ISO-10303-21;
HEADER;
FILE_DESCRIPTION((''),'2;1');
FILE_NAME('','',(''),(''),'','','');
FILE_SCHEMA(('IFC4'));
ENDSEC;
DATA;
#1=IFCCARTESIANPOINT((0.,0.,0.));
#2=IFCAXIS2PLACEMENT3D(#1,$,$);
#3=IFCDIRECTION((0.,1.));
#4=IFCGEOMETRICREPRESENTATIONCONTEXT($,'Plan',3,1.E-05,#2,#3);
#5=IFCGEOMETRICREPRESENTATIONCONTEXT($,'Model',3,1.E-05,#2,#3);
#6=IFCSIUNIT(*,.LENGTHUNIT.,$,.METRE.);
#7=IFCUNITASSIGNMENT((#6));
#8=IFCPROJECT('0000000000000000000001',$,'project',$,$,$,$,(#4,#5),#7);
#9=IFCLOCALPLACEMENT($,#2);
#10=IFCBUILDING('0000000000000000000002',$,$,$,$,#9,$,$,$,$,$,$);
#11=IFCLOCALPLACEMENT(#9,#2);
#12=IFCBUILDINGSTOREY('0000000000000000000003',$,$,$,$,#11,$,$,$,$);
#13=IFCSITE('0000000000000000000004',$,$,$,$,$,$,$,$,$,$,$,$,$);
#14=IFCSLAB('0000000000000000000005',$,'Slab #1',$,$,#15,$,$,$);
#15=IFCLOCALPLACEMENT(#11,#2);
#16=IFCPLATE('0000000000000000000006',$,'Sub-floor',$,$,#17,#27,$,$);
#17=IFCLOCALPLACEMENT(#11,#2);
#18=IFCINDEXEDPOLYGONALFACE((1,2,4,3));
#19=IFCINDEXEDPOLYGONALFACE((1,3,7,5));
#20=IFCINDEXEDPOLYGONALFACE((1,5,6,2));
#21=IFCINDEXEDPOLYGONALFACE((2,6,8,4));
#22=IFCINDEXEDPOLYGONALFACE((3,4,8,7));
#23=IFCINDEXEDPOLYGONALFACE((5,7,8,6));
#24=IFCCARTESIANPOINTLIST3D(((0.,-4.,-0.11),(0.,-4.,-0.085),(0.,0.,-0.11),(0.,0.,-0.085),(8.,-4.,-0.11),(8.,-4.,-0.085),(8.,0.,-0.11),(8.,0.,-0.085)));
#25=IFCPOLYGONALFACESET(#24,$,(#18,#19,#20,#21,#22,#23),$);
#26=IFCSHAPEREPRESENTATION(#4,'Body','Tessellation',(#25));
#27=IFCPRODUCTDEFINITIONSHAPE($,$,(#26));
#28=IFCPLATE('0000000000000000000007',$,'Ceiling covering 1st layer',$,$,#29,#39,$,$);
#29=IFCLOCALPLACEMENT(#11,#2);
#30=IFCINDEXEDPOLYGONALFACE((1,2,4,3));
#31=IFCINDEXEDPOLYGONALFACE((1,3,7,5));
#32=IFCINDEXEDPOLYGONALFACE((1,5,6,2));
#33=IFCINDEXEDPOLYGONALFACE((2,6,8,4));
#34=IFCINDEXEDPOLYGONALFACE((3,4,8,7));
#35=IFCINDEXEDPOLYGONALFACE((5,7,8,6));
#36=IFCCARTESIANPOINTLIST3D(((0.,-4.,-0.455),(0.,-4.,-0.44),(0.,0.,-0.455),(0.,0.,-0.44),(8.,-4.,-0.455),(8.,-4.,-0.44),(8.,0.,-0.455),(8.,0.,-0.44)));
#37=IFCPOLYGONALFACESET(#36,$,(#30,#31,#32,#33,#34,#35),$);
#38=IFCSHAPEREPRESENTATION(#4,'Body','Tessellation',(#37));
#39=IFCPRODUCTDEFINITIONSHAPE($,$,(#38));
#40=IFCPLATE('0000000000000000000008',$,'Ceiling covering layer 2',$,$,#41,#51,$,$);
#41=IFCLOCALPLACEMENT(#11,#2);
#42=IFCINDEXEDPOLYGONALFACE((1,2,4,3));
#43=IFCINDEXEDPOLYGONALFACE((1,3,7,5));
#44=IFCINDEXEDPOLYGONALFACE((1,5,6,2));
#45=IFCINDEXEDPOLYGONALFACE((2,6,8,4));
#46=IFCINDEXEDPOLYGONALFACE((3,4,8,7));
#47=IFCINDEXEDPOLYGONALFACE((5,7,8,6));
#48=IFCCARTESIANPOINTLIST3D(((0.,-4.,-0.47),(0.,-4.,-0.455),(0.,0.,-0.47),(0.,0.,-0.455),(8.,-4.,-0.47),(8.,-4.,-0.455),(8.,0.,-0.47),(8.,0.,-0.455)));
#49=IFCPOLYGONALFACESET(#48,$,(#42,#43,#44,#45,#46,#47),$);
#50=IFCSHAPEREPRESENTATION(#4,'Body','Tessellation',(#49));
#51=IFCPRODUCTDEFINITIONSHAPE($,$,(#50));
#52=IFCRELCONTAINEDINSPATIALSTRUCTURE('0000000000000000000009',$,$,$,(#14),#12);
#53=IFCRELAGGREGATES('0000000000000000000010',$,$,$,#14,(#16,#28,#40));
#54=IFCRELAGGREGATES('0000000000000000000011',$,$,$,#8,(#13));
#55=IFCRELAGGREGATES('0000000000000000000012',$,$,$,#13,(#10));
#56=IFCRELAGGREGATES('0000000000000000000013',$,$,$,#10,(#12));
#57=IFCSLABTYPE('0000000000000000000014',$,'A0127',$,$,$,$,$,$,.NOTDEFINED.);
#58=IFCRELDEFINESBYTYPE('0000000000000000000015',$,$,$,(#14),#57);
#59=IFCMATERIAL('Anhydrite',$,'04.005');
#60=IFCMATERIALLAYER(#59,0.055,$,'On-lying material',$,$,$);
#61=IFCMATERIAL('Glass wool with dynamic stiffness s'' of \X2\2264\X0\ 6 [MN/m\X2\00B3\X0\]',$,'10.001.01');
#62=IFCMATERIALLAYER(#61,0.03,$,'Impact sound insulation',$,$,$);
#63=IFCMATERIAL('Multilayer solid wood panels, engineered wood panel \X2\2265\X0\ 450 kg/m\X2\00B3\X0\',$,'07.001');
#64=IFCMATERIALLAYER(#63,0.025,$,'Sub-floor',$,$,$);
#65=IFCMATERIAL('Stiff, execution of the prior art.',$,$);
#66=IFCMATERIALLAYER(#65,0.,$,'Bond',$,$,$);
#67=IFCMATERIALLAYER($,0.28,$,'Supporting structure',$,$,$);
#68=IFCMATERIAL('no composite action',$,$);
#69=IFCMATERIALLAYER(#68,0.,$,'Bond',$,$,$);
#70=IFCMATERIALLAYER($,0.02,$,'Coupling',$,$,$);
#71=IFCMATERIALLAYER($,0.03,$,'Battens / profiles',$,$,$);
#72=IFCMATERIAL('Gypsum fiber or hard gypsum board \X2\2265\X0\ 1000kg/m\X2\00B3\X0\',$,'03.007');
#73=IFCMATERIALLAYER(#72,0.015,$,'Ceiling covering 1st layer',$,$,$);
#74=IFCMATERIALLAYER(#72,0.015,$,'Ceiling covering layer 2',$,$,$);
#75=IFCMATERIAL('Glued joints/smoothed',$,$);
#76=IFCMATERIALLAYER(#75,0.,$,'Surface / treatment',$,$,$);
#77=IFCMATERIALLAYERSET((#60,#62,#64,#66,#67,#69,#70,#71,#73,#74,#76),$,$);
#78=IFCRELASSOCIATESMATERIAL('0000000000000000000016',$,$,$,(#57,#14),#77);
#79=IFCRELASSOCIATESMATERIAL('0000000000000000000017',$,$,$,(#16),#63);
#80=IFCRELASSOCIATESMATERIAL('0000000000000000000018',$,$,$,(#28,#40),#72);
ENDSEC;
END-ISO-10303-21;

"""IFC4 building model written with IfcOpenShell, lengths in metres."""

from ifc_helpers import new_model, si_unit, direction, frame, frame_2d, origin, place, context, project, spatial, rectangle, extrude, material, layer, layer_set, type_object, element, aggregate, save


model = new_model("IFC4")

# Units and contexts
plan_context = context("Plan", 3, precision=1e-05, world=origin(), true_north=direction((0.0, 1.0)))
model_context = context("Model", 3, precision=1e-05, world=origin(), true_north=direction((0.0, 1.0)))
ifc_project = project(units=[si_unit("LENGTHUNIT", "METRE")], contexts=[plan_context, model_context])

# Site, building, storey
site = spatial("IfcSite", under=ifc_project)
building_placement = place(None, origin())
building = spatial("IfcBuilding", under=site, at=building_placement)
storey_placement = place(building_placement, origin())
storey = spatial("IfcBuildingStorey", under=building, at=storey_placement)

# Slab, plates
ifc_material_1 = material(Name="Anhydrite", Category="04.005")
ifc_layer_1 = layer(ifc_material_1, 0.055, Name="On-lying material")
ifc_material_2 = material(Name="Glass wool with dynamic stiffness s' of ≤ 6 [MN/m³]", Category="10.001.01")
ifc_layer_2 = layer(ifc_material_2, 0.03, Name="Impact sound insulation")
ifc_material_3 = material(Name="Multilayer solid wood panels, engineered wood panel ≥ 450 kg/m³", Category="07.001")
ifc_layer_3 = layer(ifc_material_3, 0.025, Name="Sub-floor")
ifc_material_4 = material(Name="Stiff, execution of the prior art.")
ifc_layer_4 = layer(ifc_material_4, 0.0, Name="Bond")
ifc_layer_5 = layer(None, 0.28, Name="Supporting structure")
ifc_material_5 = material(Name="no composite action")
ifc_layer_6 = layer(ifc_material_5, 0.0, Name="Bond")
ifc_layer_7 = layer(None, 0.02, Name="Coupling")
ifc_layer_8 = layer(None, 0.03, Name="Battens / profiles")
ifc_material_6 = material(Name="Gypsum fiber or hard gypsum board ≥ 1000kg/m³", Category="03.007")
ifc_layer_9 = layer(ifc_material_6, 0.015, Name="Ceiling covering 1st layer")
ifc_layer_10 = layer(ifc_material_6, 0.015, Name="Ceiling covering layer 2")
ifc_material_7 = material(Name="Glued joints/smoothed")
ifc_layer_11 = layer(ifc_material_7, 0.0, Name="Surface / treatment")
ifc_layer_set = layer_set([ifc_layer_1, ifc_layer_2, ifc_layer_3, ifc_layer_4, ifc_layer_5, ifc_layer_6, ifc_layer_7, ifc_layer_8, ifc_layer_9, ifc_layer_10, ifc_layer_11])
slab_type = type_object("IfcSlabType", Name="A0127", PredefinedType="NOTDEFINED", material=ifc_layer_set)
slab_placement = place(None, frame((0.0, 0.0, 0.0), z_axis=(0.0, 0.0, -1.0), x_axis=(1.0, 0.0, 0.0)))
slab = element("IfcSlab", 1, at=slab_placement, inside=storey, type_object=slab_type, material=ifc_layer_set, Name="Slab #1")
plate_1_placement = place(slab_placement, origin())
plate_1 = element("IfcPlate", 2, at=plate_1_placement, material=ifc_material_3, Name="Sub-floor", context=plan_context, shape_type="SweptSolid", body=[
    extrude(rectangle(XDim=8.0, YDim=4.0, at=frame_2d((4.0, 2.0), x_axis=(1.0, 0.0))), frame((0.0, 0.0, 0.085), z_axis=(0.0, 0.0, 1.0), x_axis=(1.0, 0.0, 0.0)), (0.0, 0.0, 1.0), 0.025),
])
plate_2_placement = place(slab_placement, origin())
plate_2 = element("IfcPlate", 3, at=plate_2_placement, material=ifc_material_6, Name="Ceiling covering 1st layer", context=plan_context, shape_type="SweptSolid", body=[
    extrude(rectangle(XDim=8.0, YDim=4.0, at=frame_2d((4.0, 2.0), x_axis=(1.0, 0.0))), frame((0.0, 0.0, 0.44), z_axis=(0.0, 0.0, 1.0), x_axis=(1.0, 0.0, 0.0)), (0.0, 0.0, 1.0), 0.015),
])
plate_3_placement = place(slab_placement, origin())
plate_3 = element("IfcPlate", 4, at=plate_3_placement, material=ifc_material_6, Name="Ceiling covering layer 2", context=plan_context, shape_type="SweptSolid", body=[
    extrude(rectangle(XDim=8.0, YDim=4.0, at=frame_2d((4.0, 2.0), x_axis=(1.0, 0.0))), frame((0.0, 0.0, 0.455), z_axis=(0.0, 0.0, 1.0), x_axis=(1.0, 0.0, 0.0)), (0.0, 0.0, 1.0), 0.015),
])
aggregate(slab, [plate_1, plate_2, plate_3])

save(model, "model.ifc")
